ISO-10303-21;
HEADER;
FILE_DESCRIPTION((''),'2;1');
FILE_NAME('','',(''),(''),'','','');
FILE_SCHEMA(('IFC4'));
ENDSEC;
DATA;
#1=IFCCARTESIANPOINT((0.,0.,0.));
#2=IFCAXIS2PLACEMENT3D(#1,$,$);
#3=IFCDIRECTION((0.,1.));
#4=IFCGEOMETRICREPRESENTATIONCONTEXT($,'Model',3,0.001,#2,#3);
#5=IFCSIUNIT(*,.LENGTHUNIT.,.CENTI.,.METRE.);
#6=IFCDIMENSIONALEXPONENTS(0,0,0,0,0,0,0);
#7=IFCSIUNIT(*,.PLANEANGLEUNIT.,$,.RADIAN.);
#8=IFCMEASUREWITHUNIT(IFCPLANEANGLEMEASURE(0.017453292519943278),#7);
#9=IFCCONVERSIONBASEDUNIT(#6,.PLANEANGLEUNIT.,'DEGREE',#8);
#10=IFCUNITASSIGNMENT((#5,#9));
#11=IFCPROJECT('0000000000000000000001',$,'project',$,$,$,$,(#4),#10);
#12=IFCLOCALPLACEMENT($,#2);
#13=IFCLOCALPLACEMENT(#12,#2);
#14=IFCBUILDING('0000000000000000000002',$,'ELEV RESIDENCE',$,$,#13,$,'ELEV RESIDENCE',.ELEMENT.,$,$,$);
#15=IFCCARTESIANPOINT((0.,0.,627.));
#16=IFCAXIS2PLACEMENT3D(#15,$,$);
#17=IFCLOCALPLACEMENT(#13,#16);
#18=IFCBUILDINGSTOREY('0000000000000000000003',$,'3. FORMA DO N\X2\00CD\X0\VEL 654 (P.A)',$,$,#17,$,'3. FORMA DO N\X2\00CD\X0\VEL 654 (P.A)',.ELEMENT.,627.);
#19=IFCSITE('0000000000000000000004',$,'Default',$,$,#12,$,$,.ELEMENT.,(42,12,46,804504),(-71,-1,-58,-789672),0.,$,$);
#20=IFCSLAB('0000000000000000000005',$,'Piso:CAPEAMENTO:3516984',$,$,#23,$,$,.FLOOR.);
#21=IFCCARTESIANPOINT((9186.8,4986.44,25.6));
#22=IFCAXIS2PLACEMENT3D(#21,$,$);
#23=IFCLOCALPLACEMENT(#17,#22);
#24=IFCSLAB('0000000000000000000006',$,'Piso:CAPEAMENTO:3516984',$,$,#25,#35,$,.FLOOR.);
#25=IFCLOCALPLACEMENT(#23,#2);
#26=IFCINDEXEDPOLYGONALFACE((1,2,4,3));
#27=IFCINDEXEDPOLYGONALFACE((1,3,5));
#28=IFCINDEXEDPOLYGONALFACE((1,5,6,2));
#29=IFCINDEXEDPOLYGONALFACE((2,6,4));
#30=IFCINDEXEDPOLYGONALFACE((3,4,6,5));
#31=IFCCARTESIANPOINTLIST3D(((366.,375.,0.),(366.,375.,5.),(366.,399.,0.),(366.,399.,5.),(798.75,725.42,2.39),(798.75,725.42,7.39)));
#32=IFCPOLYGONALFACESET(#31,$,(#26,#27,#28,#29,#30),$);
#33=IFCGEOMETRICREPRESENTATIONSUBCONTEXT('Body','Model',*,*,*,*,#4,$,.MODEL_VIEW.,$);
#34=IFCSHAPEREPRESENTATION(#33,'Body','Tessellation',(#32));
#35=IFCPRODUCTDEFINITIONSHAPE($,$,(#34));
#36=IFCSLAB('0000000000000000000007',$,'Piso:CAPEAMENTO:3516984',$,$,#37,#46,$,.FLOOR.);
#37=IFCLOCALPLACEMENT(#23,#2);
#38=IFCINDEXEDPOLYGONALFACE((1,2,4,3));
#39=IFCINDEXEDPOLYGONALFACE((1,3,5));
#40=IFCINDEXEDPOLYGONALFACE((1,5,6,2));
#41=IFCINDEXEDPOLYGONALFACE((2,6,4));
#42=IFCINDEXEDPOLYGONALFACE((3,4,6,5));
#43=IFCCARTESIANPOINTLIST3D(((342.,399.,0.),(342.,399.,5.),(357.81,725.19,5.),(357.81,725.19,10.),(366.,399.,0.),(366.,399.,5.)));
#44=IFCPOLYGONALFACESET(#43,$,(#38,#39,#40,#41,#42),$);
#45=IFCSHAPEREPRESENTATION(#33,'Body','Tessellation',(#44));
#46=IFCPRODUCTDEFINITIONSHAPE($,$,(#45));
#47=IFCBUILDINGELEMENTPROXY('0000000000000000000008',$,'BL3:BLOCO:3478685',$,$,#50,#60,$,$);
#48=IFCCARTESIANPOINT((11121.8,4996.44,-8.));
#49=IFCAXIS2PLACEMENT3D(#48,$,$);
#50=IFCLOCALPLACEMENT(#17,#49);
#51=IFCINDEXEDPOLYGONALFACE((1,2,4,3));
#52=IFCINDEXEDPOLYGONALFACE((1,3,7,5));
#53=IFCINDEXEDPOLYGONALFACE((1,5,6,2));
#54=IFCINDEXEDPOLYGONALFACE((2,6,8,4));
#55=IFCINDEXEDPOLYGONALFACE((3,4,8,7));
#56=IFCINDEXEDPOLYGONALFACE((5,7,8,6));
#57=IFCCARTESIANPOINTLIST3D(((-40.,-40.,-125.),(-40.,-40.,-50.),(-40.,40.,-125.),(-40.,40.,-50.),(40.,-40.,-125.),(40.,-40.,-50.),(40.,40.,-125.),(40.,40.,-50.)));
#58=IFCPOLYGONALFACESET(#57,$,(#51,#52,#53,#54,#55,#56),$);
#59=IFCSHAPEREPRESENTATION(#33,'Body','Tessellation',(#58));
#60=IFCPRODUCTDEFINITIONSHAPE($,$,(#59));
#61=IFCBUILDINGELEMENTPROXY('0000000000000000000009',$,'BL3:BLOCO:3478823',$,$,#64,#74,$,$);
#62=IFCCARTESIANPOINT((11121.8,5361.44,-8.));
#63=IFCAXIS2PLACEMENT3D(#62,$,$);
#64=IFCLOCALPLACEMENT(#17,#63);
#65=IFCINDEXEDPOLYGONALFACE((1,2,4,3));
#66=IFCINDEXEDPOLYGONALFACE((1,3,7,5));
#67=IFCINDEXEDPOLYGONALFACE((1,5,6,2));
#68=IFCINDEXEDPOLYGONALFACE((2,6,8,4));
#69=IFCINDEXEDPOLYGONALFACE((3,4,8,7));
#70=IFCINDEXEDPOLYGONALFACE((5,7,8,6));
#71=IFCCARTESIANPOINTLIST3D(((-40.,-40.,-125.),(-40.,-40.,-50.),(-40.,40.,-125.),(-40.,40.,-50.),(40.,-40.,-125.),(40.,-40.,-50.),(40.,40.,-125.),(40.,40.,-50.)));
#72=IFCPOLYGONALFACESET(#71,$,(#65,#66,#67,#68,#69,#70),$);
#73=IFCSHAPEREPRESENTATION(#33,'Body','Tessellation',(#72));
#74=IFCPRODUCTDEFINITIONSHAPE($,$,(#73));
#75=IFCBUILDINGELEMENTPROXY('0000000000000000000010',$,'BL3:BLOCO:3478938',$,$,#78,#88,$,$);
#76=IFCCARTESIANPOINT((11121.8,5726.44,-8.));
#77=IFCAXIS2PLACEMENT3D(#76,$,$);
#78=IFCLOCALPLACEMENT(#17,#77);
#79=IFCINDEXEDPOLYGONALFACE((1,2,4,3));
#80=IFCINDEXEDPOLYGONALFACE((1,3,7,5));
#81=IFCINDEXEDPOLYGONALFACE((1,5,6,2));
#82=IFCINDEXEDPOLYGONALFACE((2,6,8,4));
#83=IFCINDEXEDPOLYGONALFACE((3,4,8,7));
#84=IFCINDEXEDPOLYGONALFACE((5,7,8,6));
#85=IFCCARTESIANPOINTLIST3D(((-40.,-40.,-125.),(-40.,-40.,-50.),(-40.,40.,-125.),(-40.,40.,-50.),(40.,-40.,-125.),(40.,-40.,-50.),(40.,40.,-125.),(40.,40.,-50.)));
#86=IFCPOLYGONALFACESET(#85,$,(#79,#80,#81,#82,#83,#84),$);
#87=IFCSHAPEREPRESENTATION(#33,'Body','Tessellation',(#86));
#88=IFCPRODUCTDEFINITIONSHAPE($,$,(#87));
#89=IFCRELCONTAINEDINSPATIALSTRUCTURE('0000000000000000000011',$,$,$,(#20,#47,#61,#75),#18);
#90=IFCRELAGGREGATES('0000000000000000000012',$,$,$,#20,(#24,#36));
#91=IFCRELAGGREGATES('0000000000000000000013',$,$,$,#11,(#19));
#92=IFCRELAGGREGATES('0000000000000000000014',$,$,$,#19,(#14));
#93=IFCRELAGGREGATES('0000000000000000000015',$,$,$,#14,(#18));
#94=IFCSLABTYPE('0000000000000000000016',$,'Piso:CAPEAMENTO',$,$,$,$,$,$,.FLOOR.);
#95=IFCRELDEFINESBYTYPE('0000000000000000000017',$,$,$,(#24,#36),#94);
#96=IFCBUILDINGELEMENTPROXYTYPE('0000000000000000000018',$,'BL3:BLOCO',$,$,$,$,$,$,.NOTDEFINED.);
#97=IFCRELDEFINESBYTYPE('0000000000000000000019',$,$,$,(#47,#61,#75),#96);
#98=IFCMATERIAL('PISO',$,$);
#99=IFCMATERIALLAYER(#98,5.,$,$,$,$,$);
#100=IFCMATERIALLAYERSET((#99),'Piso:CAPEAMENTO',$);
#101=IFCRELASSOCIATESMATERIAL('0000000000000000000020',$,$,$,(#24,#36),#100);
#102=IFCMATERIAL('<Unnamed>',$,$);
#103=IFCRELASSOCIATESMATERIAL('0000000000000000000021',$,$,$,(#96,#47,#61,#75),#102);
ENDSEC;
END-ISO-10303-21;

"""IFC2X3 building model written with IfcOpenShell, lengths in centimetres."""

from ifc_helpers import new_model, entity, si_unit, converted_unit, direction, frame, frame_2d, origin, place, context, subcontext, project, spatial, polyline, rectangle, outline, extrude, source, transform, mapped, material, layer, layer_set, type_object, type_shapes, element, aggregate, save


model = new_model("IFC2X3")

# Units and contexts
model_context = context("Model", 3, precision=0.001, world=origin(), true_north=direction((0.0, 1.0)))
body_context = subcontext(model_context, "Body", "Model", "MODEL_VIEW")
ifc_project = project(units=[si_unit("LENGTHUNIT", "METRE", prefix="CENTI"), converted_unit("PLANEANGLEUNIT", "DEGREE", entity("IfcPlaneAngleMeasure", 0.017453292519943278), si_unit("PLANEANGLEUNIT", "RADIAN"), dimensions=[0, 0, 0, 0, 0, 0, 0])], contexts=[model_context])

# Site, building, storey
site_placement = place(None, origin())
site = spatial("IfcSite", under=ifc_project, at=site_placement, Name="Default", CompositionType="ELEMENT", RefLatitude=(42, 12, 46, 804504), RefLongitude=(-71, -1, -58, -789672), RefElevation=0.0)
building_placement = place(site_placement, origin())
building = spatial("IfcBuilding", under=site, at=building_placement, Name="ELEV RESIDENCE", LongName="ELEV RESIDENCE", CompositionType="ELEMENT")
storey_placement = place(building_placement, frame((0.0, 0.0, 627.0)))
storey = spatial("IfcBuildingStorey", under=building, at=storey_placement, Name="3. FORMA DO NÍVEL 654 (P.A)", LongName="3. FORMA DO NÍVEL 654 (P.A)", CompositionType="ELEMENT", Elevation=627.0)

# Slabs
slab_1_placement = place(storey_placement, frame((9186.8, 4986.44, 25.6)))
slab_1 = element("IfcSlab", 1, at=slab_1_placement, inside=storey, Name="Piso:CAPEAMENTO:3516984", PredefinedType="FLOOR")
ifc_material_1 = material(Name="PISO")
ifc_layer = layer(ifc_material_1, 5.0)
ifc_layer_set = layer_set([ifc_layer], Name="Piso:CAPEAMENTO")
slab_type = type_object("IfcSlabType", Name="Piso:CAPEAMENTO", PredefinedType="FLOOR")
slab_2_placement = place(slab_1_placement, origin())
slab_2 = element("IfcSlab", 2, at=slab_2_placement, type_object=slab_type, material=ifc_layer_set, Name="Piso:CAPEAMENTO:3516984", PredefinedType="FLOOR", context=body_context, shape_type="SweptSolid", body=[
    extrude(outline(polyline([(216.38, 175.21), (-216.38, -151.21), (-216.38, -175.21), (216.38, 175.21)])), frame((582.37, 550.21, 6.2), z_axis=(-0.00553, 0.0, 0.999985), x_axis=(0.999985, 0.0, 0.00553)), (-0.00553, 0.0, -0.999985), 5.0),
])
slab_3_placement = place(slab_1_placement, origin())
slab_3 = element("IfcSlab", 3, at=slab_3_placement, type_object=slab_type, material=ifc_layer_set, Name="Piso:CAPEAMENTO:3516984", PredefinedType="FLOOR", context=body_context, shape_type="SweptSolid", body=[
    extrude(outline(polyline([(-12.0, -163.11), (12.0, -163.11), (3.81, 163.11), (-12.0, -163.11)])), frame((354.0, 562.09, 7.5), z_axis=(0.0, -0.015327, 0.999883), x_axis=(1.0, 0.0, 0.0)), (0.0, -0.015327, -0.999883), 5.0),
])
aggregate(slab_1, [slab_2, slab_3])

# Building element proxies
ifc_material_2 = material(Name="<Unnamed>")
building_element_proxy_type_1 = type_object("IfcBuildingElementProxyType", Name="BL3:BLOCO", PredefinedType="NOTDEFINED", material=ifc_material_2)
shared_shape_1 = source(origin(), body_context, "Body", "SweptSolid", [
    extrude(rectangle(XDim=80.0, YDim=80.0, at=frame_2d((0.0, 0.0), x_axis=(1.0, 0.0))), frame((0.0, 0.0, -125.0), z_axis=(0.0, 0.0, 1.0), x_axis=(0.0, 1.0, 0.0)), (0.0, 0.0, 1.0), 75.0),
])
type_shapes(building_element_proxy_type_1, [shared_shape_1])
for number, where, name in (
    (4, (11121.8, 4996.44, -8.0), "BL3:BLOCO:3478685"),
    (5, (11121.8, 5361.44, -8.0), "BL3:BLOCO:3478823"),
    (6, (11121.8, 5726.44, -8.0), "BL3:BLOCO:3478938"),
):
    element("IfcBuildingElementProxy", number, at=place(storey_placement, frame(where)), inside=storey, type_object=building_element_proxy_type_1, material=ifc_material_2, Name=name, context=body_context, shape_type="MappedRepresentation", body=[
        mapped(shared_shape_1, transform((0.0, 0.0, 0.0), scale=1.0)),
    ])

save(model, "model.ifc")
